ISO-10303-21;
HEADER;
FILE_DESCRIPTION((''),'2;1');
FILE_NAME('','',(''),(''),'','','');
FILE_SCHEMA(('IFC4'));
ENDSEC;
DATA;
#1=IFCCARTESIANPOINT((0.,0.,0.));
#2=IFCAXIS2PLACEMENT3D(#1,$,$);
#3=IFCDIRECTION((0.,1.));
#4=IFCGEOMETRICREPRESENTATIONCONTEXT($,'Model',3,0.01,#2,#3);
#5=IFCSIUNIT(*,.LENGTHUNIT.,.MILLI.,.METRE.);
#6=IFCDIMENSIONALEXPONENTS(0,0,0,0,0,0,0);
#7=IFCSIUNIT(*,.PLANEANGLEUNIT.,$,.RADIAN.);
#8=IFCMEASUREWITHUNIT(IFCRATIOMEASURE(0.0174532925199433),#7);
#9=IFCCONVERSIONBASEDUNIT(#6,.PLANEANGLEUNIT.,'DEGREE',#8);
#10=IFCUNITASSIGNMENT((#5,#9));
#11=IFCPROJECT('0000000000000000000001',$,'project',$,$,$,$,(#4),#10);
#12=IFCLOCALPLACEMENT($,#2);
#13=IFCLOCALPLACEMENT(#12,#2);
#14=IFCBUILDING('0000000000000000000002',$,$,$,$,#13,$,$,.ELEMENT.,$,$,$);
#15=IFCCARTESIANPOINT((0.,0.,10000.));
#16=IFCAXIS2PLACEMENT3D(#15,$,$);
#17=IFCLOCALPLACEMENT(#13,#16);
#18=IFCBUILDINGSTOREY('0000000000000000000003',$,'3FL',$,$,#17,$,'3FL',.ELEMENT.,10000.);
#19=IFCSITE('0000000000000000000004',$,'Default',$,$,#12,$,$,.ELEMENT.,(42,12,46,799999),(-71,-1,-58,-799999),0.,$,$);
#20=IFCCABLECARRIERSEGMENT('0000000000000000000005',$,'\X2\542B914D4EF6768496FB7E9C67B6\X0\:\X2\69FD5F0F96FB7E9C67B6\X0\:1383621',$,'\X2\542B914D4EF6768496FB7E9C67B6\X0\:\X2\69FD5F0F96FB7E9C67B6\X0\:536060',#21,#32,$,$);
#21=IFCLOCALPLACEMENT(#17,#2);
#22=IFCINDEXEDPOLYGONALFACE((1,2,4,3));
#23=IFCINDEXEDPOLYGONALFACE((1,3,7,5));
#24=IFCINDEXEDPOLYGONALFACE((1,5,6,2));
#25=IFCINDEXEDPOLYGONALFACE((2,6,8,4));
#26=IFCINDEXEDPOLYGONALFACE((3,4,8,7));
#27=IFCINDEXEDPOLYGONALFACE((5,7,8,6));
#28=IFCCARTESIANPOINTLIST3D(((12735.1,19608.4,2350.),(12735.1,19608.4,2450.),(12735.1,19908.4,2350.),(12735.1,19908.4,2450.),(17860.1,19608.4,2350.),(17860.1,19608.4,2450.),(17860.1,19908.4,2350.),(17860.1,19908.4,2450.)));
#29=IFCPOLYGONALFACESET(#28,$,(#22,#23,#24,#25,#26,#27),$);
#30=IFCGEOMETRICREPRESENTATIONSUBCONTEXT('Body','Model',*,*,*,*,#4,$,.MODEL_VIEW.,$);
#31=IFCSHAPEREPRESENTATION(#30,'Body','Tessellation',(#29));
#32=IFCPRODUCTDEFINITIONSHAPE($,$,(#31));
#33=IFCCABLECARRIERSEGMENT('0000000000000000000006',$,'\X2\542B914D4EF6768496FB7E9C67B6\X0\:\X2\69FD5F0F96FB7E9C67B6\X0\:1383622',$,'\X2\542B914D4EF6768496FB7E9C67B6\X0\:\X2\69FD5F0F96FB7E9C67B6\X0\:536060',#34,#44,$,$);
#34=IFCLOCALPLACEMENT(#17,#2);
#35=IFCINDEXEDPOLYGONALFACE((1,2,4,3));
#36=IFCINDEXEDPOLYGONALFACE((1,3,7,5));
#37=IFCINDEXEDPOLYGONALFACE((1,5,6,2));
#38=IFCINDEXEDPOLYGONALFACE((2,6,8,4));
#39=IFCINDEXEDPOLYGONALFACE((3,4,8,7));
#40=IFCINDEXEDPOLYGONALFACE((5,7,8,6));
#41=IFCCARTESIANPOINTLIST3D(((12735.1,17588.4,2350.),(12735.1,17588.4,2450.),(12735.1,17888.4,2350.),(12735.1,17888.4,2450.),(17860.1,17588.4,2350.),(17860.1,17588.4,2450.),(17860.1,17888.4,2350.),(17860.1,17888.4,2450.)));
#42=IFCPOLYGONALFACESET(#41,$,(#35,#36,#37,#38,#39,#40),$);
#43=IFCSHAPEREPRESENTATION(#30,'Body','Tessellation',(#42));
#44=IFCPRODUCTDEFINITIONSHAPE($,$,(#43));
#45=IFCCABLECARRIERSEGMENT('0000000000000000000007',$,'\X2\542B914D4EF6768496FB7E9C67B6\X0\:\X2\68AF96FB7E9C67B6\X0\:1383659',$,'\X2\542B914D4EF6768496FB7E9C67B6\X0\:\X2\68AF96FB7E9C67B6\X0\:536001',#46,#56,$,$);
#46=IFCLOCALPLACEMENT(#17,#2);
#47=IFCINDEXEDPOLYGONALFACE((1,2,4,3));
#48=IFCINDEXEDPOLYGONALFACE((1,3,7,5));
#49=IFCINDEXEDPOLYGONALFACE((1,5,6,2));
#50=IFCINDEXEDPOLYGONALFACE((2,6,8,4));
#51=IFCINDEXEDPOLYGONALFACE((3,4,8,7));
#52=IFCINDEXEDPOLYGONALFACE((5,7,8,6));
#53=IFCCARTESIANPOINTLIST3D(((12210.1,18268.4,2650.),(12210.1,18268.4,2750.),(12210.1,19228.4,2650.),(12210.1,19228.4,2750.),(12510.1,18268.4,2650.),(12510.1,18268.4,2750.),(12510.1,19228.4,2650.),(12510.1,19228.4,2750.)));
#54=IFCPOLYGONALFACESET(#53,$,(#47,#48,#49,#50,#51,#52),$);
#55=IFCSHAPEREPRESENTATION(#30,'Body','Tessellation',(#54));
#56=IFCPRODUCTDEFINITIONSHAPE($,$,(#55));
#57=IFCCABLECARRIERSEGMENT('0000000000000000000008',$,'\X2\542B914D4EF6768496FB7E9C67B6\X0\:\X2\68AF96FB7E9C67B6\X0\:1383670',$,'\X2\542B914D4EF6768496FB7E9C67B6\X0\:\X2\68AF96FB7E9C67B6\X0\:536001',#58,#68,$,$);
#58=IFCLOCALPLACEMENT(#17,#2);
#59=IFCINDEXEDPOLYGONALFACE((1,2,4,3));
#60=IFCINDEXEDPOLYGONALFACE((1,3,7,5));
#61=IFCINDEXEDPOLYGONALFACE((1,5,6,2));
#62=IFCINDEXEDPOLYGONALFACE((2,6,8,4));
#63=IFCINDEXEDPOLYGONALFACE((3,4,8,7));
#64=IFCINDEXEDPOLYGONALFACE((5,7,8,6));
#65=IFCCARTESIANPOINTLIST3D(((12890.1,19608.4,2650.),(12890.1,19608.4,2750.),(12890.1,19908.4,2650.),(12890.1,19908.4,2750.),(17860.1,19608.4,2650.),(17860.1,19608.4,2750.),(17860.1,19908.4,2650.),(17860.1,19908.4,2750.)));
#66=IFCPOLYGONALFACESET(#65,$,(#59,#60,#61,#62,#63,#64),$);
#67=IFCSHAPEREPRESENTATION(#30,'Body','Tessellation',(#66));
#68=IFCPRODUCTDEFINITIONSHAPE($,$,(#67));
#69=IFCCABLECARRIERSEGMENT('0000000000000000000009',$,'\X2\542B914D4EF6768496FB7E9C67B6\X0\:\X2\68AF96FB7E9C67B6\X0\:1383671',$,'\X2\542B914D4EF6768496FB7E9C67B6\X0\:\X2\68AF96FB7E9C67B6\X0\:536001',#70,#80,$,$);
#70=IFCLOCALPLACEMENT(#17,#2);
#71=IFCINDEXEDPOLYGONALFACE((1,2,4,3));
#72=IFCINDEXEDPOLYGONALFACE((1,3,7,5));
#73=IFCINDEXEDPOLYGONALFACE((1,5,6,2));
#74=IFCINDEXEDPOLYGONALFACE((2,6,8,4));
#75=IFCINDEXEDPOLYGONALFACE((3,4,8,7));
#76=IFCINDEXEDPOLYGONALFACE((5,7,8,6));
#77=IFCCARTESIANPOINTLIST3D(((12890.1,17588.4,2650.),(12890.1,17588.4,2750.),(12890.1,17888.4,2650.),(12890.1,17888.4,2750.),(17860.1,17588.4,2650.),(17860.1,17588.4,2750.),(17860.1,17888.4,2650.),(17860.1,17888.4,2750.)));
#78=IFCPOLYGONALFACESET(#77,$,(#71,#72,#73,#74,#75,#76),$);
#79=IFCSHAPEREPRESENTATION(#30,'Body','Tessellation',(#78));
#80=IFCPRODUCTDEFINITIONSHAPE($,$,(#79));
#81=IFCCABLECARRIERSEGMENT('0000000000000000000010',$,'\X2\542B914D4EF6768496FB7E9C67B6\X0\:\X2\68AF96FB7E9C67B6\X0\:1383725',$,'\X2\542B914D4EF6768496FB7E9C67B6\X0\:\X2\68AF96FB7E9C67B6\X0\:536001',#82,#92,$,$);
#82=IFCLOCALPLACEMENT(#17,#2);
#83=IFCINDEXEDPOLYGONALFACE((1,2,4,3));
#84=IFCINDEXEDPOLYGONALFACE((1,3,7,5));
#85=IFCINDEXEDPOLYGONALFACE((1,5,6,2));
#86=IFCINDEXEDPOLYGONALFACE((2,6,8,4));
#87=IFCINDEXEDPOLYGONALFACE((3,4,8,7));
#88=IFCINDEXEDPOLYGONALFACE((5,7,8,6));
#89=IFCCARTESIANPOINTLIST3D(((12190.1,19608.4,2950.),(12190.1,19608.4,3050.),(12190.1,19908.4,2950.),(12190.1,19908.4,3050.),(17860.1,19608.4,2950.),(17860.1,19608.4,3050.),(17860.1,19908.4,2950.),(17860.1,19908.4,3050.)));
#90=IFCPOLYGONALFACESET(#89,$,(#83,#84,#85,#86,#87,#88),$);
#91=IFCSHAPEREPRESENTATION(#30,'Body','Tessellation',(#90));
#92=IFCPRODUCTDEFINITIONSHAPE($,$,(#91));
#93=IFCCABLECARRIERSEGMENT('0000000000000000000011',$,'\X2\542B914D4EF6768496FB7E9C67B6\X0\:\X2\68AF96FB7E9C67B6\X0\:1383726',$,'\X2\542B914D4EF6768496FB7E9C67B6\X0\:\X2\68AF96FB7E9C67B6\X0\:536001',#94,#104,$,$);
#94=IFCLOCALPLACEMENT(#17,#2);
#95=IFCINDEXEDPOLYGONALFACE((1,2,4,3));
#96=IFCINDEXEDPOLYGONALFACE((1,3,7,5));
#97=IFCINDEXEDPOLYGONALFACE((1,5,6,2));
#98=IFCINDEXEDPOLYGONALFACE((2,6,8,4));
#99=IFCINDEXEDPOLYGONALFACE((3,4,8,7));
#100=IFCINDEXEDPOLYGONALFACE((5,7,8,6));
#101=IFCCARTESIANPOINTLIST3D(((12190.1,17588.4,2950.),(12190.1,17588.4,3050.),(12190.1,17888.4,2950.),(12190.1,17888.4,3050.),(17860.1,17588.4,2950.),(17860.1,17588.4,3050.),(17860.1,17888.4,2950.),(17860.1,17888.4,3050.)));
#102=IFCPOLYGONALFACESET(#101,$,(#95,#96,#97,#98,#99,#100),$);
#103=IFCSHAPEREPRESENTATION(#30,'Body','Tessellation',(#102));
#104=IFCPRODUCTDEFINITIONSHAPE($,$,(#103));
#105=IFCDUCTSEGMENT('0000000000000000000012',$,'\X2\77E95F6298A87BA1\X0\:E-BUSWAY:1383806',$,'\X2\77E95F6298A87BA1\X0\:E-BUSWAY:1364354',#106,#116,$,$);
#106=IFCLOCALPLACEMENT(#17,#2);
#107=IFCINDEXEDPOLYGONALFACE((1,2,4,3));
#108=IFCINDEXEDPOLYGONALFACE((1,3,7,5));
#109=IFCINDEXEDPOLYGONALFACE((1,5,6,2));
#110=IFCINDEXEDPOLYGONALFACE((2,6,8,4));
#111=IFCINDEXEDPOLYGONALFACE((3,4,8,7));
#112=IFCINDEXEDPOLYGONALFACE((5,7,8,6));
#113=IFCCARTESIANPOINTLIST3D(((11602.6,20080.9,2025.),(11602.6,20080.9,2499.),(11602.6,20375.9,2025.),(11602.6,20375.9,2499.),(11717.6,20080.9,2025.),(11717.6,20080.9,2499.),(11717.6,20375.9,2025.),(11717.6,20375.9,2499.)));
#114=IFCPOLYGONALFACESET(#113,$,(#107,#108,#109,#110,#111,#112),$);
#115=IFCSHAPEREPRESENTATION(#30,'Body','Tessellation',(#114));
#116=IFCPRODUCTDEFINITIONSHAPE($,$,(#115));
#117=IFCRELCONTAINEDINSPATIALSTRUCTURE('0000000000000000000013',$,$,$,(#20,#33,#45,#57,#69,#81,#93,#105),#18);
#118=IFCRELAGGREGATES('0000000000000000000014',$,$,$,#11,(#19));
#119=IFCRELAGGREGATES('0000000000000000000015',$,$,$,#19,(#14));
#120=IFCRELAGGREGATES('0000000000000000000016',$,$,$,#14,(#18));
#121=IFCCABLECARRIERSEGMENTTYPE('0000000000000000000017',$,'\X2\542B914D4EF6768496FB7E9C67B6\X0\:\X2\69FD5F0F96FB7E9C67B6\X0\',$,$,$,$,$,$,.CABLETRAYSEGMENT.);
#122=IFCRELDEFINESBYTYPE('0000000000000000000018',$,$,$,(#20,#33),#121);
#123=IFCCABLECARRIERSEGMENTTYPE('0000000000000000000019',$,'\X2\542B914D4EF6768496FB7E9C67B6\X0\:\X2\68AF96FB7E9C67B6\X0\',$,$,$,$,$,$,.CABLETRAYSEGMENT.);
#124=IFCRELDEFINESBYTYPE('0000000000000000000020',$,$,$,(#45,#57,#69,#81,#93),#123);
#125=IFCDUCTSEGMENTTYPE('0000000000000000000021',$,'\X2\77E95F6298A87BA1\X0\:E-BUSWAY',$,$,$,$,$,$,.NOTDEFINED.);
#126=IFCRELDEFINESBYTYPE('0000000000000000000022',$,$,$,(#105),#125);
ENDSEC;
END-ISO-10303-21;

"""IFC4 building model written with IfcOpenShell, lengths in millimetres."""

from ifc_helpers import new_model, entity, si_unit, converted_unit, direction, frame, frame_2d, origin, origin_2d_with_axis, place, context, subcontext, project, spatial, rectangle, extrude, type_object, element, save


model = new_model("IFC4")

# Units and contexts
model_context = context("Model", 3, precision=0.01, world=origin(), true_north=direction((0.0, 1.0)))
body_context = subcontext(model_context, "Body", "Model", "MODEL_VIEW")
ifc_project = project(units=[si_unit("LENGTHUNIT", "METRE", prefix="MILLI"), converted_unit("PLANEANGLEUNIT", "DEGREE", entity("IfcRatioMeasure", 0.0174532925199433), si_unit("PLANEANGLEUNIT", "RADIAN"), dimensions=[0, 0, 0, 0, 0, 0, 0])], contexts=[model_context])

# Site, building, storey
site_placement = place(None, origin())
site = spatial("IfcSite", under=ifc_project, at=site_placement, Name="Default", CompositionType="ELEMENT", RefLatitude=(42, 12, 46, 799999), RefLongitude=(-71, -1, -58, -799999), RefElevation=0.0)
building_placement = place(site_placement, origin())
building = spatial("IfcBuilding", under=site, at=building_placement, CompositionType="ELEMENT")
storey_placement = place(building_placement, frame((0.0, 0.0, 10000.0)))
storey = spatial("IfcBuildingStorey", under=building, at=storey_placement, Name="3FL", LongName="3FL", CompositionType="ELEMENT", Elevation=10000.0)

# Cable carrier segments
cable_carrier_segment_type_1 = type_object("IfcCableCarrierSegmentType", Name="含配件的電纜架:槽式電纜架", PredefinedType="CABLETRAYSEGMENT")
cable_carrier_segment_1_placement = place(storey_placement, frame((12735.1, 19608.4, 2350.0)))
element("IfcCableCarrierSegment", 1, at=cable_carrier_segment_1_placement, inside=storey, type_object=cable_carrier_segment_type_1, Name="含配件的電纜架:槽式電纜架:1383621", ObjectType="含配件的電纜架:槽式電纜架:536060", context=body_context, shape_type="SweptSolid", body=[
    extrude(rectangle(XDim=5125.0, YDim=300.0, at=frame_2d((0.0, 0.0), x_axis=(1.0, 0.0))), frame((2562.5, 150.0, 0.0), z_axis=(0.0, 0.0, 1.0), x_axis=(-1.0, 0.0, 0.0)), (0.0, 0.0, 1.0), 100.0),
])
cable_carrier_segment_2_placement = place(storey_placement, frame((12735.1, 17588.4, 2350.0)))
element("IfcCableCarrierSegment", 2, at=cable_carrier_segment_2_placement, inside=storey, type_object=cable_carrier_segment_type_1, Name="含配件的電纜架:槽式電纜架:1383622", ObjectType="含配件的電纜架:槽式電纜架:536060", context=body_context, shape_type="SweptSolid", body=[
    extrude(rectangle(XDim=5125.0, YDim=300.0, at=frame_2d((0.0, 0.0), x_axis=(1.0, 0.0))), frame((2562.5, 150.0, 0.0), z_axis=(0.0, 0.0, 1.0), x_axis=(-1.0, 0.0, 0.0)), (0.0, 0.0, 1.0), 100.0),
])
cable_carrier_segment_type_2 = type_object("IfcCableCarrierSegmentType", Name="含配件的電纜架:梯電纜架", PredefinedType="CABLETRAYSEGMENT")
cable_carrier_segment_3_placement = place(storey_placement, frame((12210.1, 18268.4, 2650.0)))
element("IfcCableCarrierSegment", 3, at=cable_carrier_segment_3_placement, inside=storey, type_object=cable_carrier_segment_type_2, Name="含配件的電纜架:梯電纜架:1383659", ObjectType="含配件的電纜架:梯電纜架:536001", context=body_context, shape_type="SweptSolid", body=[
    extrude(rectangle(XDim=960.0, YDim=300.0, at=origin_2d_with_axis()), frame((150.0, 480.0, 0.0), z_axis=(0.0, 0.0, 1.0), x_axis=(0.0, 1.0, 0.0)), (0.0, 0.0, 1.0), 100.0),
])
cable_carrier_segment_4_placement = place(storey_placement, frame((12890.1, 19608.4, 2650.0)))
element("IfcCableCarrierSegment", 4, at=cable_carrier_segment_4_placement, inside=storey, type_object=cable_carrier_segment_type_2, Name="含配件的電纜架:梯電纜架:1383670", ObjectType="含配件的電纜架:梯電纜架:536001", context=body_context, shape_type="SweptSolid", body=[
    extrude(rectangle(XDim=4970.0, YDim=300.0, at=origin_2d_with_axis()), frame((2485.0, 150.0, 0.0), z_axis=(0.0, 0.0, 1.0), x_axis=(-1.0, 0.0, 0.0)), (0.0, 0.0, 1.0), 100.0),
])
cable_carrier_segment_5_placement = place(storey_placement, frame((12890.1, 17588.4, 2650.0)))
element("IfcCableCarrierSegment", 5, at=cable_carrier_segment_5_placement, inside=storey, type_object=cable_carrier_segment_type_2, Name="含配件的電纜架:梯電纜架:1383671", ObjectType="含配件的電纜架:梯電纜架:536001", context=body_context, shape_type="SweptSolid", body=[
    extrude(rectangle(XDim=4970.0, YDim=300.0, at=frame_2d((0.0, 0.0), x_axis=(1.0, 0.0))), frame((2485.0, 150.0, 0.0), z_axis=(0.0, 0.0, 1.0), x_axis=(-1.0, 0.0, 0.0)), (0.0, 0.0, 1.0), 100.0),
])
cable_carrier_segment_6_placement = place(storey_placement, frame((12190.1, 19608.4, 2950.0)))
element("IfcCableCarrierSegment", 6, at=cable_carrier_segment_6_placement, inside=storey, type_object=cable_carrier_segment_type_2, Name="含配件的電纜架:梯電纜架:1383725", ObjectType="含配件的電纜架:梯電纜架:536001", context=body_context, shape_type="SweptSolid", body=[
    extrude(rectangle(XDim=5670.0, YDim=300.0, at=frame_2d((0.0, 0.0), x_axis=(1.0, 0.0))), frame((2835.0, 150.0, 0.0), z_axis=(0.0, 0.0, 1.0), x_axis=(-1.0, 0.0, 0.0)), (0.0, 0.0, 1.0), 100.0),
])
cable_carrier_segment_7_placement = place(storey_placement, frame((12190.1, 17588.4, 2950.0)))
element("IfcCableCarrierSegment", 7, at=cable_carrier_segment_7_placement, inside=storey, type_object=cable_carrier_segment_type_2, Name="含配件的電纜架:梯電纜架:1383726", ObjectType="含配件的電纜架:梯電纜架:536001", context=body_context, shape_type="SweptSolid", body=[
    extrude(rectangle(XDim=5670.0, YDim=300.0, at=origin_2d_with_axis()), frame((2835.0, 150.0, 0.0), z_axis=(0.0, 0.0, 1.0), x_axis=(-1.0, 0.0, 0.0)), (0.0, 0.0, 1.0), 100.0),
])

# Duct segment
duct_segment_type = type_object("IfcDuctSegmentType", Name="矩形風管:E-BUSWAY", PredefinedType="NOTDEFINED")
duct_segment_placement = place(storey_placement, frame((11602.6, 20080.9, 2025.0)))
element("IfcDuctSegment", 8, at=duct_segment_placement, inside=storey, type_object=duct_segment_type, Name="矩形風管:E-BUSWAY:1383806", ObjectType="矩形風管:E-BUSWAY:1364354", context=body_context, shape_type="SweptSolid", body=[
    extrude(rectangle(XDim=115.0, YDim=295.0, at=origin_2d_with_axis()), frame((57.5, 147.5, 0.0), z_axis=(0.0, 0.0, 1.0), x_axis=(-1.0, 0.0, 0.0)), (0.0, 0.0, 1.0), 474.0),
])

save(model, "model.ifc")
